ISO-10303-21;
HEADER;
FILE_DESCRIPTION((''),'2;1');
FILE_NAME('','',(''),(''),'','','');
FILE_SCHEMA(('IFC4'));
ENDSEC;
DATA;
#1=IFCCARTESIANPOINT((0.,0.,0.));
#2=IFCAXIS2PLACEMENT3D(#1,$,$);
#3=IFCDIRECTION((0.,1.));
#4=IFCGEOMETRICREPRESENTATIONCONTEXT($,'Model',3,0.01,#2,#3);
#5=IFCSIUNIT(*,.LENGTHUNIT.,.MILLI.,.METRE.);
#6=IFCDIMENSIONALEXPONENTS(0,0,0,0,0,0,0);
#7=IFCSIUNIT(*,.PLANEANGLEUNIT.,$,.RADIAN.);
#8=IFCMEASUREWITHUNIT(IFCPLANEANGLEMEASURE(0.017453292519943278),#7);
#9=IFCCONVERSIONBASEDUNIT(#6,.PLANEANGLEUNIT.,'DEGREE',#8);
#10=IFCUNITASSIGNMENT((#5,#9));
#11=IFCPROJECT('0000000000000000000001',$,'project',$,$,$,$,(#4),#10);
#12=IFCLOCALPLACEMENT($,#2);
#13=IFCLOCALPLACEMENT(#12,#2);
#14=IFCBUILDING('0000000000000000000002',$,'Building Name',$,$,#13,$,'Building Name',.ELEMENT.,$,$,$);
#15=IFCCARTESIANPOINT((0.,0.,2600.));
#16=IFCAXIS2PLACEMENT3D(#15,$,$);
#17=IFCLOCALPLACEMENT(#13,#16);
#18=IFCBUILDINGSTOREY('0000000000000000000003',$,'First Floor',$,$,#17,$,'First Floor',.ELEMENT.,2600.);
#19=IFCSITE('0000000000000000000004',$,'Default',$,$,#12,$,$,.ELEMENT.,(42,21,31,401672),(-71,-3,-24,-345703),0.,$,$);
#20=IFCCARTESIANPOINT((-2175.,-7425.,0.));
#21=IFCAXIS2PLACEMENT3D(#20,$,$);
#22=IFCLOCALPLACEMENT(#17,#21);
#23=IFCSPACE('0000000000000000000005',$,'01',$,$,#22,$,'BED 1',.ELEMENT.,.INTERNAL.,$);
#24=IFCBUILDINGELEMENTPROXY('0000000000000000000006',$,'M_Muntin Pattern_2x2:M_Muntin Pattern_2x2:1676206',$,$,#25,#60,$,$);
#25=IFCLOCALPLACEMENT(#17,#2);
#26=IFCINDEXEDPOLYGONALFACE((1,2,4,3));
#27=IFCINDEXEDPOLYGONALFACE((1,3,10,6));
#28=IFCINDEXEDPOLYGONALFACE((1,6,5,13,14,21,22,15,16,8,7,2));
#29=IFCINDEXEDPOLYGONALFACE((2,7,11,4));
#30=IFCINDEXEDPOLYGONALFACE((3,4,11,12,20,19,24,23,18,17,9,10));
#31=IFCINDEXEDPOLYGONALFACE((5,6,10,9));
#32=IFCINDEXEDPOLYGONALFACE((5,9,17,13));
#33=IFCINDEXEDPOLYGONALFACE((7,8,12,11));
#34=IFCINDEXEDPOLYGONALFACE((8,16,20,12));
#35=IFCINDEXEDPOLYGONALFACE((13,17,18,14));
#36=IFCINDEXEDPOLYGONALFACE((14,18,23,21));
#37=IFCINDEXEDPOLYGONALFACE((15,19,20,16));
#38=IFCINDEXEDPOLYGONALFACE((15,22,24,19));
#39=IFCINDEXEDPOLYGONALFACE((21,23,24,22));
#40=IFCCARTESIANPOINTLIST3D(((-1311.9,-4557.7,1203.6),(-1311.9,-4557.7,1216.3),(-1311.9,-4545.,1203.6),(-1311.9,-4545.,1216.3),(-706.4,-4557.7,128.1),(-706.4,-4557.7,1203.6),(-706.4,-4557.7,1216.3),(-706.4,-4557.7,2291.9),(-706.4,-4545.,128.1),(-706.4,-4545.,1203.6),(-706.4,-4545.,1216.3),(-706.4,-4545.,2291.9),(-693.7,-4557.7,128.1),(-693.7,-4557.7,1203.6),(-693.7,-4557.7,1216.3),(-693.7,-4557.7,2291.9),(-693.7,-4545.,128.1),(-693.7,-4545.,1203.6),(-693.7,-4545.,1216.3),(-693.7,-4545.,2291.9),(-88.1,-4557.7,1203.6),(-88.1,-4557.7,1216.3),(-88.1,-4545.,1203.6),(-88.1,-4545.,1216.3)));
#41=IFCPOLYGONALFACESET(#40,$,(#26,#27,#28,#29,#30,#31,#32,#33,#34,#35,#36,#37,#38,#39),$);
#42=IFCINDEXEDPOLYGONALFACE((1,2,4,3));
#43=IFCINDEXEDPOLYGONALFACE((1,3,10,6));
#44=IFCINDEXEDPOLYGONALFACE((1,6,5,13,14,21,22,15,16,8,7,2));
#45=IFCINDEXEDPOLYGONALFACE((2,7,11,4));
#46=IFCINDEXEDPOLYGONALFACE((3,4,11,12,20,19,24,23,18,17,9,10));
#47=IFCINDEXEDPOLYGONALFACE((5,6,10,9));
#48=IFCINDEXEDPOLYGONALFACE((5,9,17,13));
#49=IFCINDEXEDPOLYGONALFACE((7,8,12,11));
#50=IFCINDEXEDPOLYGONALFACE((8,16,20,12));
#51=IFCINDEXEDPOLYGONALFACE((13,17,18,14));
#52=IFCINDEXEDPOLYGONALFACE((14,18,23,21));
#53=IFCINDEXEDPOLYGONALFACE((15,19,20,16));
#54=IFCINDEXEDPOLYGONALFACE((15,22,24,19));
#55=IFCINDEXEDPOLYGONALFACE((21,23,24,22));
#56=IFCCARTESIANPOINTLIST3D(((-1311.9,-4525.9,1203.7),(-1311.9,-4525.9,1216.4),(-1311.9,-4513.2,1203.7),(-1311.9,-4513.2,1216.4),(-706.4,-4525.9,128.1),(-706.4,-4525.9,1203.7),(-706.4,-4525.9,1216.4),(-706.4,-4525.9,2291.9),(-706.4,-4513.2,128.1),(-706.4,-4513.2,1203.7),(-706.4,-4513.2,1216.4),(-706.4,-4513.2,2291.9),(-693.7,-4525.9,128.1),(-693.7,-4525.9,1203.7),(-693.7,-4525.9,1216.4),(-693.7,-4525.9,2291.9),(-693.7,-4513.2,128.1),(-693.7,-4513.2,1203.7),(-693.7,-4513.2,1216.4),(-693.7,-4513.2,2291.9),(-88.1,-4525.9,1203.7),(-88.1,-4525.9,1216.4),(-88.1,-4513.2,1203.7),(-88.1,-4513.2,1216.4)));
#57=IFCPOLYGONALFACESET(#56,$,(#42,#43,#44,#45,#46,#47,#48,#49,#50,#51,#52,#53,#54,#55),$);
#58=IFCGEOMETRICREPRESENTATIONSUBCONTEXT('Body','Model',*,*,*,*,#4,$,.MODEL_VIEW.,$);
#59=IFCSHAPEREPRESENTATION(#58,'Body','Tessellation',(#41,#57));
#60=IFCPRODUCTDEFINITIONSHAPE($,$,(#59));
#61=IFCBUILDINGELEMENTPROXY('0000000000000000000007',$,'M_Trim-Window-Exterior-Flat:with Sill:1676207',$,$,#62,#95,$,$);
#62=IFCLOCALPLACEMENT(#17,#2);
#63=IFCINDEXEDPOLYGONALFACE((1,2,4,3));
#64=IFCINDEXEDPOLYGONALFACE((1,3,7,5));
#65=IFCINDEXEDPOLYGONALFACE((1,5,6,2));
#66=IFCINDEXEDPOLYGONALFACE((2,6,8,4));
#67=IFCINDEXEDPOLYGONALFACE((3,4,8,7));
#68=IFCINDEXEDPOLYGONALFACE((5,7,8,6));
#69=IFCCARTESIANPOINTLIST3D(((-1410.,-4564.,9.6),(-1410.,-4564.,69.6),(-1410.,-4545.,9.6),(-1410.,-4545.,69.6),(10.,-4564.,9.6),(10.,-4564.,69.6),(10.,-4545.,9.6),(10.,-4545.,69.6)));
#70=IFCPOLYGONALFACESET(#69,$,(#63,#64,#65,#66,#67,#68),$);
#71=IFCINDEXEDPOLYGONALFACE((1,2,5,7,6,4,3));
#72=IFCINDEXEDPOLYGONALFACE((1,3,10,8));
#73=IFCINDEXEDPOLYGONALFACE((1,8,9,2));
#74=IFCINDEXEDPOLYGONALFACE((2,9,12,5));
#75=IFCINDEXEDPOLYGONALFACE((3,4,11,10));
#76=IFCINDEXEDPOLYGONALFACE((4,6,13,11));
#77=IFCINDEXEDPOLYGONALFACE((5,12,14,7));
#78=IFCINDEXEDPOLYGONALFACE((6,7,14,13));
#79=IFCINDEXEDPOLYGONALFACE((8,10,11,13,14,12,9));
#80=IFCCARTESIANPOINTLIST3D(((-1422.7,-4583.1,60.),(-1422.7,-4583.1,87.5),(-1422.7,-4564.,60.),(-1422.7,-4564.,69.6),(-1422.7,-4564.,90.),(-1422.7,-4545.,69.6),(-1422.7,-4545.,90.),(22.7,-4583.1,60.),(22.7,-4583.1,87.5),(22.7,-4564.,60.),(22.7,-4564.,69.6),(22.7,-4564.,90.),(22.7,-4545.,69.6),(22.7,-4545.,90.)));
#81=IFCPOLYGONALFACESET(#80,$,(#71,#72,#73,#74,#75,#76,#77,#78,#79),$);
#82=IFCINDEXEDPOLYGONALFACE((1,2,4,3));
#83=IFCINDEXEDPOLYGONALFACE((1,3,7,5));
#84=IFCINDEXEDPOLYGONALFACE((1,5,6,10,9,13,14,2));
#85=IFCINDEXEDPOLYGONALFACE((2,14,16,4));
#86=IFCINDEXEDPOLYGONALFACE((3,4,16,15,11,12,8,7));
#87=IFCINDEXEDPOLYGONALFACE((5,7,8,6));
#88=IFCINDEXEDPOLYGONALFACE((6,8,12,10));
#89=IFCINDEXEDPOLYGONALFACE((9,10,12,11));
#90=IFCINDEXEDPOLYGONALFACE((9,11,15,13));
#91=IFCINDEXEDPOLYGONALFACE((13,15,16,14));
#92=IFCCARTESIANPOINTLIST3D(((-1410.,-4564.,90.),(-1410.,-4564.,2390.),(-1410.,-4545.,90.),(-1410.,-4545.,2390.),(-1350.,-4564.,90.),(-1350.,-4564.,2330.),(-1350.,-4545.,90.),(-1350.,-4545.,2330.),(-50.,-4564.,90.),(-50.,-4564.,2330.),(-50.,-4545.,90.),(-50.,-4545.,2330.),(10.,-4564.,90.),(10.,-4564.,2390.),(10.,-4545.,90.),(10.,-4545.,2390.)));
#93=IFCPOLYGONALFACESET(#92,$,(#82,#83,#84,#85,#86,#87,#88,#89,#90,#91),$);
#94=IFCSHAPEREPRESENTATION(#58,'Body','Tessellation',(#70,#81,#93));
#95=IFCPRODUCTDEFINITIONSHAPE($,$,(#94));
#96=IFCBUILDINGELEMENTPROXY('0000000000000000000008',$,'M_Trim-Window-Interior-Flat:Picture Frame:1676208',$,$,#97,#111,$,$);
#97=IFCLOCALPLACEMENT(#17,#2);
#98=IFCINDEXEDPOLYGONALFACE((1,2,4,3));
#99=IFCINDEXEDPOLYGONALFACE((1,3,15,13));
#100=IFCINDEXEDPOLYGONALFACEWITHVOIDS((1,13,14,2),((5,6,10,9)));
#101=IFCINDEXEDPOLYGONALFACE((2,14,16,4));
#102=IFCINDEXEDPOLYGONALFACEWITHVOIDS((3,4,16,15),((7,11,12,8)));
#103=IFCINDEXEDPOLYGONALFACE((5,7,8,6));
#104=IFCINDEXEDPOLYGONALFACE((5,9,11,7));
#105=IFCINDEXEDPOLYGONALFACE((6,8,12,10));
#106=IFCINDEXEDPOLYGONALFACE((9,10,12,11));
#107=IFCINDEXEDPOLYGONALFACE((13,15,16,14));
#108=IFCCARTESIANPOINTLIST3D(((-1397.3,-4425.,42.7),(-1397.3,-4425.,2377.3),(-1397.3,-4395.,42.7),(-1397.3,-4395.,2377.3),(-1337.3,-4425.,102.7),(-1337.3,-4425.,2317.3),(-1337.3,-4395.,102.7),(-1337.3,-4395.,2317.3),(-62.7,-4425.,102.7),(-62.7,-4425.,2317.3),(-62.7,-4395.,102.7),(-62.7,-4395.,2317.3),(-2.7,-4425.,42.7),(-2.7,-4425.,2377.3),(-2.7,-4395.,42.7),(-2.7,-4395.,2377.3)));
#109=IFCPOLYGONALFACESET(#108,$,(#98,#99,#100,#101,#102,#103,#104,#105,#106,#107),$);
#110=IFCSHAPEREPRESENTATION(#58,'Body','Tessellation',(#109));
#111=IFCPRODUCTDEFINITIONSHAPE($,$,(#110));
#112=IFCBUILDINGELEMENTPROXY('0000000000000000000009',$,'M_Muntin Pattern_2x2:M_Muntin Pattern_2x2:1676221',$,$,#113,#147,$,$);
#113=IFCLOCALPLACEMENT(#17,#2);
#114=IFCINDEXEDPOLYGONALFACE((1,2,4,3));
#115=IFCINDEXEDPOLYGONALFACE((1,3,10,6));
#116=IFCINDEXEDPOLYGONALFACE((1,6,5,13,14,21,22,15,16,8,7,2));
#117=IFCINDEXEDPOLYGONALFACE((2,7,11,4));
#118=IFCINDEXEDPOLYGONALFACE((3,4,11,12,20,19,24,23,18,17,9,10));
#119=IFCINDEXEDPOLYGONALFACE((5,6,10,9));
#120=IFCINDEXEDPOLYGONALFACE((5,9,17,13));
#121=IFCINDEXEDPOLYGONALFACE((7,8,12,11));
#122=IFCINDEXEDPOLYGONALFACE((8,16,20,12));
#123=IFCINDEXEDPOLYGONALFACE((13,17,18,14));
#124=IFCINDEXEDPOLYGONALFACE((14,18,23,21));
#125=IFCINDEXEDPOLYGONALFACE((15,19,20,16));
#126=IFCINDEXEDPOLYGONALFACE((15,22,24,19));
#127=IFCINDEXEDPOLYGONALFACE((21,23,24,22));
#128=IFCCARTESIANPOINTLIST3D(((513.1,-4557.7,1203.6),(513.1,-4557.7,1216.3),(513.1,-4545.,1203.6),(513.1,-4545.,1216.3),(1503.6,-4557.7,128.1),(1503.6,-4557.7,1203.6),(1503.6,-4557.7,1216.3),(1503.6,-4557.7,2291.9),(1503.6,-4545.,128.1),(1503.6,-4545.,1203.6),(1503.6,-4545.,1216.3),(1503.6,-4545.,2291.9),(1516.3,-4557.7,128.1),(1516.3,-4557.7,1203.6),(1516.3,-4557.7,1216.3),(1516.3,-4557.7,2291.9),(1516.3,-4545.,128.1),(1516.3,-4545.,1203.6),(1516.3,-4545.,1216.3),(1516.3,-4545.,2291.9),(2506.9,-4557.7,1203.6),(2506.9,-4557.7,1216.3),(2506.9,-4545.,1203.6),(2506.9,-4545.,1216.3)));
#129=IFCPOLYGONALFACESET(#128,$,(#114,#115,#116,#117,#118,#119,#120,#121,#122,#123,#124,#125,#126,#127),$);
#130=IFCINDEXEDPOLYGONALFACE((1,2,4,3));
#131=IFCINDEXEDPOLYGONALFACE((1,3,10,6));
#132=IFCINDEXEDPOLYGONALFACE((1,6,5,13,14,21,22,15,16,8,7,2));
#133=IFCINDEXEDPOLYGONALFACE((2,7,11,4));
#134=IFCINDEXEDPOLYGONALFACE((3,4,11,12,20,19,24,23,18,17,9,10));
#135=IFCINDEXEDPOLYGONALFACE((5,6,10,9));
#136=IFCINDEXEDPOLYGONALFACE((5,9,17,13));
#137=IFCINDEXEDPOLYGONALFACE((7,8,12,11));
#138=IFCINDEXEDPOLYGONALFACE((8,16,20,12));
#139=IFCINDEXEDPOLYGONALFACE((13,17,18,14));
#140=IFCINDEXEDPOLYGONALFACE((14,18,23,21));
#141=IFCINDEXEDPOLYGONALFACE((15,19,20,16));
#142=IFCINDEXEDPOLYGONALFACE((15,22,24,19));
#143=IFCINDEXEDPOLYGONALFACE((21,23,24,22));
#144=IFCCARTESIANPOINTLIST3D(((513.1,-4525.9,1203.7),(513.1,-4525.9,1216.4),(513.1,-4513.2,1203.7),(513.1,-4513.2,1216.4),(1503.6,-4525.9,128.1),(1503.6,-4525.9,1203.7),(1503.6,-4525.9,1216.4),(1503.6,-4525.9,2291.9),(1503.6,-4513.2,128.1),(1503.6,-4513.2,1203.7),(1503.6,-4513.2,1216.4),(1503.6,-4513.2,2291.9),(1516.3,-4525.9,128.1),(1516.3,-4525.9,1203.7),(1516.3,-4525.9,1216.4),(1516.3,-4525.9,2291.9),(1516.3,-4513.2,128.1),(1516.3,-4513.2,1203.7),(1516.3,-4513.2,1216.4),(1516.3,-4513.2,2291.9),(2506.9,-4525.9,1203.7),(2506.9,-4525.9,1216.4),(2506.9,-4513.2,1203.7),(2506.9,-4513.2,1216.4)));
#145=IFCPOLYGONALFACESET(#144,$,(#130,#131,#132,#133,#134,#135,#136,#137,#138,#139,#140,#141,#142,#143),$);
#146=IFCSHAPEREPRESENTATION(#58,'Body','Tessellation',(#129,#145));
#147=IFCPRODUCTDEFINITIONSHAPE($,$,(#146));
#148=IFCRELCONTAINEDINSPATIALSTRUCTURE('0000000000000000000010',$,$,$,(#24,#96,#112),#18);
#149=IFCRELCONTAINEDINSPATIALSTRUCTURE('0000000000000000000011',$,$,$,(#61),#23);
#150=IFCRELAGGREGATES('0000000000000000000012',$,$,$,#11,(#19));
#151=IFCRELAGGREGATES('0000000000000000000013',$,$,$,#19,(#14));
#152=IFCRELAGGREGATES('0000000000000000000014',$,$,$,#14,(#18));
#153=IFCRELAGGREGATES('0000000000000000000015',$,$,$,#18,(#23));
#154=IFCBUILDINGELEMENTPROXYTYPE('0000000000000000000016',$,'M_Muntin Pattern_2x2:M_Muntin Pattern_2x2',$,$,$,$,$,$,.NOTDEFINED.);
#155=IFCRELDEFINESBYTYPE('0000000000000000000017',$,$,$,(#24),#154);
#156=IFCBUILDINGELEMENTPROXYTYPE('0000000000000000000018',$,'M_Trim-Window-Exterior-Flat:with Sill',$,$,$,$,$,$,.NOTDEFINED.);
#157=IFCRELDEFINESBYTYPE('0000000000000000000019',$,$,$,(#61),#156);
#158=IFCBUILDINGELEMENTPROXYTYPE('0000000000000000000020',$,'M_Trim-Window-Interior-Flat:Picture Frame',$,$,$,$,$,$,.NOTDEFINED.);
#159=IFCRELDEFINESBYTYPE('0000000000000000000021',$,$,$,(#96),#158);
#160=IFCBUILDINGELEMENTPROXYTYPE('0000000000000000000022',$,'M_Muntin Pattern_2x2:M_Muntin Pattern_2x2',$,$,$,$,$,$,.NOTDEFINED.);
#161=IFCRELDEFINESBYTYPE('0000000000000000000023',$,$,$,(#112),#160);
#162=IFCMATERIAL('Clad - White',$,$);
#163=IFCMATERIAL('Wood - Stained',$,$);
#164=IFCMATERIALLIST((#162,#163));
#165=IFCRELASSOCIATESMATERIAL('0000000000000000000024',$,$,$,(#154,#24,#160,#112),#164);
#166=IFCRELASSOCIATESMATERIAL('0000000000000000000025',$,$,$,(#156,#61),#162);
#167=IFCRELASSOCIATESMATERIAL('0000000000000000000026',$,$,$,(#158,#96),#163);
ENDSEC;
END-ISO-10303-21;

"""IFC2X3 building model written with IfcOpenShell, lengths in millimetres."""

from ifc_helpers import new_model, entity, si_unit, converted_unit, direction, frame, frame_2d, origin, place, context, subcontext, project, spatial, polyline, rectangle, outline, extrude, source, transform, mapped, material, material_list, type_object, type_shapes, element, save


model = new_model("IFC2X3")

# Units and contexts
model_context = context("Model", 3, precision=0.01, world=origin(), true_north=direction((0.0, 1.0)))
body_context = subcontext(model_context, "Body", "Model", "MODEL_VIEW")
ifc_project = project(units=[si_unit("LENGTHUNIT", "METRE", prefix="MILLI"), converted_unit("PLANEANGLEUNIT", "DEGREE", entity("IfcPlaneAngleMeasure", 0.017453292519943278), si_unit("PLANEANGLEUNIT", "RADIAN"), dimensions=[0, 0, 0, 0, 0, 0, 0])], contexts=[model_context])

# Site, building, storey
site_placement = place(None, origin())
site = spatial("IfcSite", under=ifc_project, at=site_placement, Name="Default", CompositionType="ELEMENT", RefLatitude=(42, 21, 31, 401672), RefLongitude=(-71, -3, -24, -345703), RefElevation=0.0)
building_placement = place(site_placement, origin())
building = spatial("IfcBuilding", under=site, at=building_placement, Name="Building Name", LongName="Building Name", CompositionType="ELEMENT")
storey_placement = place(building_placement, frame((0.0, 0.0, 2600.0)))
storey = spatial("IfcBuildingStorey", under=building, at=storey_placement, Name="First Floor", LongName="First Floor", CompositionType="ELEMENT", Elevation=2600.0)

# Shared definitions
space_1_placement = place(storey_placement, frame((-2175.0, -7425.0, 0.0)))
space_1 = spatial("IfcSpace", under=storey, at=space_1_placement, Name="01", LongName="BED 1", CompositionType="ELEMENT", InteriorOrExteriorSpace="INTERNAL")

# Building element proxies
ifc_material_1 = material(Name="Clad - White")
ifc_material_2 = material(Name="Wood - Stained")
ifc_material_list_1 = material_list([ifc_material_1, ifc_material_2])
building_element_proxy_type_1 = type_object("IfcBuildingElementProxyType", Name="M_Muntin Pattern_2x2:M_Muntin Pattern_2x2", PredefinedType="NOTDEFINED", material=ifc_material_list_1)
shared_shape_1 = source(origin(), body_context, "Body", "SweptSolid", [
    extrude(outline(polyline([(6.4, -6.4), (1081.9, -6.4), (1081.9, 6.3), (6.4, 6.3), (6.4, 611.9), (-6.3, 611.9), (-6.3, 6.3), (-1081.9, 6.3), (-1081.9, -6.4), (-6.3, -6.4), (-6.3, -611.9), (6.4, -611.9), (6.4, -6.4)])), frame((0.0, -22.2, 1081.9), z_axis=(0.0, 1.0, 0.0), x_axis=(0.0, 0.0, 1.0)), (0.0, 0.0, 1.0), 12.7),
    extrude(outline(polyline([(6.4, -6.4), (1081.9, -6.4), (1081.9, 6.3), (6.4, 6.3), (6.4, 611.9), (-6.3, 611.9), (-6.3, 6.3), (-1081.9, 6.3), (-1081.9, -6.4), (-6.3, -6.4), (-6.3, -611.9), (6.4, -611.9), (6.4, -6.4)])), frame((0.0, 9.5, 1081.9), z_axis=(0.0, 1.0, 0.0), x_axis=(0.0, 0.0, 1.0)), (0.0, 0.0, 1.0), 12.7),
])
type_shapes(building_element_proxy_type_1, [shared_shape_1])
proxy_1_placement = place(storey_placement, frame((-700.0, -4535.5, 128.1)))
element("IfcBuildingElementProxy", 1, at=proxy_1_placement, inside=storey, type_object=building_element_proxy_type_1, material=ifc_material_list_1, Name="M_Muntin Pattern_2x2:M_Muntin Pattern_2x2:1676206", context=body_context, shape_type="MappedRepresentation", body=[
    mapped(shared_shape_1, transform((0.0, 0.0, 0.0), scale=1.0)),
])
building_element_proxy_type_2 = type_object("IfcBuildingElementProxyType", Name="M_Trim-Window-Exterior-Flat:with Sill", PredefinedType="NOTDEFINED", material=ifc_material_1)
shared_shape_2 = source(origin(), body_context, "Body", "SweptSolid", [
    extrude(rectangle(XDim=1420.0, YDim=60.0, at=frame_2d((0.0, 0.0), x_axis=(1.0, 0.0))), frame((0.0, -2290.4, 0.0), z_axis=(0.0, 0.0, 1.0), x_axis=(-1.0, 0.0, 0.0)), (0.0, 0.0, 1.0), 19.0),
    extrude(outline(polyline([(-19.0, -15.2), (0.0, -15.2), (0.0, -5.7), (19.0, -5.7), (19.0, 14.8), (0.0, 14.8), (-19.0, 12.3), (-19.0, -15.2)])), frame((-722.7, -2254.8, 19.0), z_axis=(1.0, 0.0, 0.0), x_axis=(0.0, 0.0, -1.0)), (0.0, 0.0, 1.0), 1445.4),
    extrude(outline(polyline([(-1165.0, -710.0), (1135.0, -710.0), (1135.0, -650.0), (-1105.0, -650.0), (-1105.0, 650.0), (1135.0, 650.0), (1135.0, 710.0), (-1165.0, 710.0), (-1165.0, -710.0)])), frame((0.0, -1105.0, 0.0), z_axis=(0.0, 0.0, 1.0), x_axis=(0.0, -1.0, 0.0)), (0.0, 0.0, 1.0), 19.0),
])
type_shapes(building_element_proxy_type_2, [shared_shape_2])
proxy_2_placement = place(space_1_placement, frame((1475.0, 2880.0, 2330.0), z_axis=(0.0, -1.0, 0.0), x_axis=(1.0, 0.0, 0.0)))
element("IfcBuildingElementProxy", 2, at=proxy_2_placement, inside=space_1, type_object=building_element_proxy_type_2, material=ifc_material_1, Name="M_Trim-Window-Exterior-Flat:with Sill:1676207", context=body_context, shape_type="MappedRepresentation", body=[
    mapped(shared_shape_2, transform((0.0, 0.0, 0.0), scale=1.0)),
])
building_element_proxy_type_3 = type_object("IfcBuildingElementProxyType", Name="M_Trim-Window-Interior-Flat:Picture Frame", PredefinedType="NOTDEFINED", material=ifc_material_2)
shared_shape_3 = source(origin(), body_context, "Body", "SweptSolid", [
    extrude(outline(polyline([(-697.3, -1167.3), (697.3, -1167.3), (697.3, 1167.3), (-697.3, 1167.3), (-697.3, -1167.3)]), holes=[polyline([(-637.3, -1107.3), (-637.3, 1107.3), (637.3, 1107.3), (637.3, -1107.3), (-637.3, -1107.3)])]), frame((0.0, -1120.0, 0.0), z_axis=(0.0, 0.0, 1.0), x_axis=(-1.0, 0.0, 0.0)), (0.0, 0.0, 1.0), 30.0),
])
type_shapes(building_element_proxy_type_3, [shared_shape_3])
proxy_3_placement = place(storey_placement, frame((-700.0, -4425.0, 2330.0), z_axis=(0.0, 1.0, 0.0), x_axis=(-1.0, 0.0, 0.0)))
element("IfcBuildingElementProxy", 3, at=proxy_3_placement, inside=storey, type_object=building_element_proxy_type_3, material=ifc_material_2, Name="M_Trim-Window-Interior-Flat:Picture Frame:1676208", context=body_context, shape_type="MappedRepresentation", body=[
    mapped(shared_shape_3, transform((0.0, 0.0, 0.0), scale=1.0)),
])
building_element_proxy_type_4 = type_object("IfcBuildingElementProxyType", Name="M_Muntin Pattern_2x2:M_Muntin Pattern_2x2", PredefinedType="NOTDEFINED", material=ifc_material_list_1)
shared_shape_4 = source(origin(), body_context, "Body", "SweptSolid", [
    extrude(outline(polyline([(6.4, -6.4), (1081.9, -6.4), (1081.9, 6.3), (6.4, 6.3), (6.4, 996.9), (-6.3, 996.9), (-6.3, 6.3), (-1081.9, 6.3), (-1081.9, -6.4), (-6.3, -6.4), (-6.3, -996.9), (6.4, -996.9), (6.4, -6.4)])), frame((0.0, -22.2, 1081.9), z_axis=(0.0, 1.0, 0.0), x_axis=(0.0, 0.0, 1.0)), (0.0, 0.0, 1.0), 12.7),
    extrude(outline(polyline([(6.4, -6.4), (1081.9, -6.4), (1081.9, 6.3), (6.4, 6.3), (6.4, 996.9), (-6.3, 996.9), (-6.3, 6.3), (-1081.9, 6.3), (-1081.9, -6.4), (-6.3, -6.4), (-6.3, -996.9), (6.4, -996.9), (6.4, -6.4)])), frame((0.0, 9.5, 1081.9), z_axis=(0.0, 1.0, 0.0), x_axis=(0.0, 0.0, 1.0)), (0.0, 0.0, 1.0), 12.7),
])
type_shapes(building_element_proxy_type_4, [shared_shape_4])
proxy_4_placement = place(storey_placement, frame((1510.0, -4535.5, 128.1)))
element("IfcBuildingElementProxy", 4, at=proxy_4_placement, inside=storey, type_object=building_element_proxy_type_4, material=ifc_material_list_1, Name="M_Muntin Pattern_2x2:M_Muntin Pattern_2x2:1676221", context=body_context, shape_type="MappedRepresentation", body=[
    mapped(shared_shape_4, transform((0.0, 0.0, 0.0), scale=1.0)),
])

save(model, "model.ifc")
